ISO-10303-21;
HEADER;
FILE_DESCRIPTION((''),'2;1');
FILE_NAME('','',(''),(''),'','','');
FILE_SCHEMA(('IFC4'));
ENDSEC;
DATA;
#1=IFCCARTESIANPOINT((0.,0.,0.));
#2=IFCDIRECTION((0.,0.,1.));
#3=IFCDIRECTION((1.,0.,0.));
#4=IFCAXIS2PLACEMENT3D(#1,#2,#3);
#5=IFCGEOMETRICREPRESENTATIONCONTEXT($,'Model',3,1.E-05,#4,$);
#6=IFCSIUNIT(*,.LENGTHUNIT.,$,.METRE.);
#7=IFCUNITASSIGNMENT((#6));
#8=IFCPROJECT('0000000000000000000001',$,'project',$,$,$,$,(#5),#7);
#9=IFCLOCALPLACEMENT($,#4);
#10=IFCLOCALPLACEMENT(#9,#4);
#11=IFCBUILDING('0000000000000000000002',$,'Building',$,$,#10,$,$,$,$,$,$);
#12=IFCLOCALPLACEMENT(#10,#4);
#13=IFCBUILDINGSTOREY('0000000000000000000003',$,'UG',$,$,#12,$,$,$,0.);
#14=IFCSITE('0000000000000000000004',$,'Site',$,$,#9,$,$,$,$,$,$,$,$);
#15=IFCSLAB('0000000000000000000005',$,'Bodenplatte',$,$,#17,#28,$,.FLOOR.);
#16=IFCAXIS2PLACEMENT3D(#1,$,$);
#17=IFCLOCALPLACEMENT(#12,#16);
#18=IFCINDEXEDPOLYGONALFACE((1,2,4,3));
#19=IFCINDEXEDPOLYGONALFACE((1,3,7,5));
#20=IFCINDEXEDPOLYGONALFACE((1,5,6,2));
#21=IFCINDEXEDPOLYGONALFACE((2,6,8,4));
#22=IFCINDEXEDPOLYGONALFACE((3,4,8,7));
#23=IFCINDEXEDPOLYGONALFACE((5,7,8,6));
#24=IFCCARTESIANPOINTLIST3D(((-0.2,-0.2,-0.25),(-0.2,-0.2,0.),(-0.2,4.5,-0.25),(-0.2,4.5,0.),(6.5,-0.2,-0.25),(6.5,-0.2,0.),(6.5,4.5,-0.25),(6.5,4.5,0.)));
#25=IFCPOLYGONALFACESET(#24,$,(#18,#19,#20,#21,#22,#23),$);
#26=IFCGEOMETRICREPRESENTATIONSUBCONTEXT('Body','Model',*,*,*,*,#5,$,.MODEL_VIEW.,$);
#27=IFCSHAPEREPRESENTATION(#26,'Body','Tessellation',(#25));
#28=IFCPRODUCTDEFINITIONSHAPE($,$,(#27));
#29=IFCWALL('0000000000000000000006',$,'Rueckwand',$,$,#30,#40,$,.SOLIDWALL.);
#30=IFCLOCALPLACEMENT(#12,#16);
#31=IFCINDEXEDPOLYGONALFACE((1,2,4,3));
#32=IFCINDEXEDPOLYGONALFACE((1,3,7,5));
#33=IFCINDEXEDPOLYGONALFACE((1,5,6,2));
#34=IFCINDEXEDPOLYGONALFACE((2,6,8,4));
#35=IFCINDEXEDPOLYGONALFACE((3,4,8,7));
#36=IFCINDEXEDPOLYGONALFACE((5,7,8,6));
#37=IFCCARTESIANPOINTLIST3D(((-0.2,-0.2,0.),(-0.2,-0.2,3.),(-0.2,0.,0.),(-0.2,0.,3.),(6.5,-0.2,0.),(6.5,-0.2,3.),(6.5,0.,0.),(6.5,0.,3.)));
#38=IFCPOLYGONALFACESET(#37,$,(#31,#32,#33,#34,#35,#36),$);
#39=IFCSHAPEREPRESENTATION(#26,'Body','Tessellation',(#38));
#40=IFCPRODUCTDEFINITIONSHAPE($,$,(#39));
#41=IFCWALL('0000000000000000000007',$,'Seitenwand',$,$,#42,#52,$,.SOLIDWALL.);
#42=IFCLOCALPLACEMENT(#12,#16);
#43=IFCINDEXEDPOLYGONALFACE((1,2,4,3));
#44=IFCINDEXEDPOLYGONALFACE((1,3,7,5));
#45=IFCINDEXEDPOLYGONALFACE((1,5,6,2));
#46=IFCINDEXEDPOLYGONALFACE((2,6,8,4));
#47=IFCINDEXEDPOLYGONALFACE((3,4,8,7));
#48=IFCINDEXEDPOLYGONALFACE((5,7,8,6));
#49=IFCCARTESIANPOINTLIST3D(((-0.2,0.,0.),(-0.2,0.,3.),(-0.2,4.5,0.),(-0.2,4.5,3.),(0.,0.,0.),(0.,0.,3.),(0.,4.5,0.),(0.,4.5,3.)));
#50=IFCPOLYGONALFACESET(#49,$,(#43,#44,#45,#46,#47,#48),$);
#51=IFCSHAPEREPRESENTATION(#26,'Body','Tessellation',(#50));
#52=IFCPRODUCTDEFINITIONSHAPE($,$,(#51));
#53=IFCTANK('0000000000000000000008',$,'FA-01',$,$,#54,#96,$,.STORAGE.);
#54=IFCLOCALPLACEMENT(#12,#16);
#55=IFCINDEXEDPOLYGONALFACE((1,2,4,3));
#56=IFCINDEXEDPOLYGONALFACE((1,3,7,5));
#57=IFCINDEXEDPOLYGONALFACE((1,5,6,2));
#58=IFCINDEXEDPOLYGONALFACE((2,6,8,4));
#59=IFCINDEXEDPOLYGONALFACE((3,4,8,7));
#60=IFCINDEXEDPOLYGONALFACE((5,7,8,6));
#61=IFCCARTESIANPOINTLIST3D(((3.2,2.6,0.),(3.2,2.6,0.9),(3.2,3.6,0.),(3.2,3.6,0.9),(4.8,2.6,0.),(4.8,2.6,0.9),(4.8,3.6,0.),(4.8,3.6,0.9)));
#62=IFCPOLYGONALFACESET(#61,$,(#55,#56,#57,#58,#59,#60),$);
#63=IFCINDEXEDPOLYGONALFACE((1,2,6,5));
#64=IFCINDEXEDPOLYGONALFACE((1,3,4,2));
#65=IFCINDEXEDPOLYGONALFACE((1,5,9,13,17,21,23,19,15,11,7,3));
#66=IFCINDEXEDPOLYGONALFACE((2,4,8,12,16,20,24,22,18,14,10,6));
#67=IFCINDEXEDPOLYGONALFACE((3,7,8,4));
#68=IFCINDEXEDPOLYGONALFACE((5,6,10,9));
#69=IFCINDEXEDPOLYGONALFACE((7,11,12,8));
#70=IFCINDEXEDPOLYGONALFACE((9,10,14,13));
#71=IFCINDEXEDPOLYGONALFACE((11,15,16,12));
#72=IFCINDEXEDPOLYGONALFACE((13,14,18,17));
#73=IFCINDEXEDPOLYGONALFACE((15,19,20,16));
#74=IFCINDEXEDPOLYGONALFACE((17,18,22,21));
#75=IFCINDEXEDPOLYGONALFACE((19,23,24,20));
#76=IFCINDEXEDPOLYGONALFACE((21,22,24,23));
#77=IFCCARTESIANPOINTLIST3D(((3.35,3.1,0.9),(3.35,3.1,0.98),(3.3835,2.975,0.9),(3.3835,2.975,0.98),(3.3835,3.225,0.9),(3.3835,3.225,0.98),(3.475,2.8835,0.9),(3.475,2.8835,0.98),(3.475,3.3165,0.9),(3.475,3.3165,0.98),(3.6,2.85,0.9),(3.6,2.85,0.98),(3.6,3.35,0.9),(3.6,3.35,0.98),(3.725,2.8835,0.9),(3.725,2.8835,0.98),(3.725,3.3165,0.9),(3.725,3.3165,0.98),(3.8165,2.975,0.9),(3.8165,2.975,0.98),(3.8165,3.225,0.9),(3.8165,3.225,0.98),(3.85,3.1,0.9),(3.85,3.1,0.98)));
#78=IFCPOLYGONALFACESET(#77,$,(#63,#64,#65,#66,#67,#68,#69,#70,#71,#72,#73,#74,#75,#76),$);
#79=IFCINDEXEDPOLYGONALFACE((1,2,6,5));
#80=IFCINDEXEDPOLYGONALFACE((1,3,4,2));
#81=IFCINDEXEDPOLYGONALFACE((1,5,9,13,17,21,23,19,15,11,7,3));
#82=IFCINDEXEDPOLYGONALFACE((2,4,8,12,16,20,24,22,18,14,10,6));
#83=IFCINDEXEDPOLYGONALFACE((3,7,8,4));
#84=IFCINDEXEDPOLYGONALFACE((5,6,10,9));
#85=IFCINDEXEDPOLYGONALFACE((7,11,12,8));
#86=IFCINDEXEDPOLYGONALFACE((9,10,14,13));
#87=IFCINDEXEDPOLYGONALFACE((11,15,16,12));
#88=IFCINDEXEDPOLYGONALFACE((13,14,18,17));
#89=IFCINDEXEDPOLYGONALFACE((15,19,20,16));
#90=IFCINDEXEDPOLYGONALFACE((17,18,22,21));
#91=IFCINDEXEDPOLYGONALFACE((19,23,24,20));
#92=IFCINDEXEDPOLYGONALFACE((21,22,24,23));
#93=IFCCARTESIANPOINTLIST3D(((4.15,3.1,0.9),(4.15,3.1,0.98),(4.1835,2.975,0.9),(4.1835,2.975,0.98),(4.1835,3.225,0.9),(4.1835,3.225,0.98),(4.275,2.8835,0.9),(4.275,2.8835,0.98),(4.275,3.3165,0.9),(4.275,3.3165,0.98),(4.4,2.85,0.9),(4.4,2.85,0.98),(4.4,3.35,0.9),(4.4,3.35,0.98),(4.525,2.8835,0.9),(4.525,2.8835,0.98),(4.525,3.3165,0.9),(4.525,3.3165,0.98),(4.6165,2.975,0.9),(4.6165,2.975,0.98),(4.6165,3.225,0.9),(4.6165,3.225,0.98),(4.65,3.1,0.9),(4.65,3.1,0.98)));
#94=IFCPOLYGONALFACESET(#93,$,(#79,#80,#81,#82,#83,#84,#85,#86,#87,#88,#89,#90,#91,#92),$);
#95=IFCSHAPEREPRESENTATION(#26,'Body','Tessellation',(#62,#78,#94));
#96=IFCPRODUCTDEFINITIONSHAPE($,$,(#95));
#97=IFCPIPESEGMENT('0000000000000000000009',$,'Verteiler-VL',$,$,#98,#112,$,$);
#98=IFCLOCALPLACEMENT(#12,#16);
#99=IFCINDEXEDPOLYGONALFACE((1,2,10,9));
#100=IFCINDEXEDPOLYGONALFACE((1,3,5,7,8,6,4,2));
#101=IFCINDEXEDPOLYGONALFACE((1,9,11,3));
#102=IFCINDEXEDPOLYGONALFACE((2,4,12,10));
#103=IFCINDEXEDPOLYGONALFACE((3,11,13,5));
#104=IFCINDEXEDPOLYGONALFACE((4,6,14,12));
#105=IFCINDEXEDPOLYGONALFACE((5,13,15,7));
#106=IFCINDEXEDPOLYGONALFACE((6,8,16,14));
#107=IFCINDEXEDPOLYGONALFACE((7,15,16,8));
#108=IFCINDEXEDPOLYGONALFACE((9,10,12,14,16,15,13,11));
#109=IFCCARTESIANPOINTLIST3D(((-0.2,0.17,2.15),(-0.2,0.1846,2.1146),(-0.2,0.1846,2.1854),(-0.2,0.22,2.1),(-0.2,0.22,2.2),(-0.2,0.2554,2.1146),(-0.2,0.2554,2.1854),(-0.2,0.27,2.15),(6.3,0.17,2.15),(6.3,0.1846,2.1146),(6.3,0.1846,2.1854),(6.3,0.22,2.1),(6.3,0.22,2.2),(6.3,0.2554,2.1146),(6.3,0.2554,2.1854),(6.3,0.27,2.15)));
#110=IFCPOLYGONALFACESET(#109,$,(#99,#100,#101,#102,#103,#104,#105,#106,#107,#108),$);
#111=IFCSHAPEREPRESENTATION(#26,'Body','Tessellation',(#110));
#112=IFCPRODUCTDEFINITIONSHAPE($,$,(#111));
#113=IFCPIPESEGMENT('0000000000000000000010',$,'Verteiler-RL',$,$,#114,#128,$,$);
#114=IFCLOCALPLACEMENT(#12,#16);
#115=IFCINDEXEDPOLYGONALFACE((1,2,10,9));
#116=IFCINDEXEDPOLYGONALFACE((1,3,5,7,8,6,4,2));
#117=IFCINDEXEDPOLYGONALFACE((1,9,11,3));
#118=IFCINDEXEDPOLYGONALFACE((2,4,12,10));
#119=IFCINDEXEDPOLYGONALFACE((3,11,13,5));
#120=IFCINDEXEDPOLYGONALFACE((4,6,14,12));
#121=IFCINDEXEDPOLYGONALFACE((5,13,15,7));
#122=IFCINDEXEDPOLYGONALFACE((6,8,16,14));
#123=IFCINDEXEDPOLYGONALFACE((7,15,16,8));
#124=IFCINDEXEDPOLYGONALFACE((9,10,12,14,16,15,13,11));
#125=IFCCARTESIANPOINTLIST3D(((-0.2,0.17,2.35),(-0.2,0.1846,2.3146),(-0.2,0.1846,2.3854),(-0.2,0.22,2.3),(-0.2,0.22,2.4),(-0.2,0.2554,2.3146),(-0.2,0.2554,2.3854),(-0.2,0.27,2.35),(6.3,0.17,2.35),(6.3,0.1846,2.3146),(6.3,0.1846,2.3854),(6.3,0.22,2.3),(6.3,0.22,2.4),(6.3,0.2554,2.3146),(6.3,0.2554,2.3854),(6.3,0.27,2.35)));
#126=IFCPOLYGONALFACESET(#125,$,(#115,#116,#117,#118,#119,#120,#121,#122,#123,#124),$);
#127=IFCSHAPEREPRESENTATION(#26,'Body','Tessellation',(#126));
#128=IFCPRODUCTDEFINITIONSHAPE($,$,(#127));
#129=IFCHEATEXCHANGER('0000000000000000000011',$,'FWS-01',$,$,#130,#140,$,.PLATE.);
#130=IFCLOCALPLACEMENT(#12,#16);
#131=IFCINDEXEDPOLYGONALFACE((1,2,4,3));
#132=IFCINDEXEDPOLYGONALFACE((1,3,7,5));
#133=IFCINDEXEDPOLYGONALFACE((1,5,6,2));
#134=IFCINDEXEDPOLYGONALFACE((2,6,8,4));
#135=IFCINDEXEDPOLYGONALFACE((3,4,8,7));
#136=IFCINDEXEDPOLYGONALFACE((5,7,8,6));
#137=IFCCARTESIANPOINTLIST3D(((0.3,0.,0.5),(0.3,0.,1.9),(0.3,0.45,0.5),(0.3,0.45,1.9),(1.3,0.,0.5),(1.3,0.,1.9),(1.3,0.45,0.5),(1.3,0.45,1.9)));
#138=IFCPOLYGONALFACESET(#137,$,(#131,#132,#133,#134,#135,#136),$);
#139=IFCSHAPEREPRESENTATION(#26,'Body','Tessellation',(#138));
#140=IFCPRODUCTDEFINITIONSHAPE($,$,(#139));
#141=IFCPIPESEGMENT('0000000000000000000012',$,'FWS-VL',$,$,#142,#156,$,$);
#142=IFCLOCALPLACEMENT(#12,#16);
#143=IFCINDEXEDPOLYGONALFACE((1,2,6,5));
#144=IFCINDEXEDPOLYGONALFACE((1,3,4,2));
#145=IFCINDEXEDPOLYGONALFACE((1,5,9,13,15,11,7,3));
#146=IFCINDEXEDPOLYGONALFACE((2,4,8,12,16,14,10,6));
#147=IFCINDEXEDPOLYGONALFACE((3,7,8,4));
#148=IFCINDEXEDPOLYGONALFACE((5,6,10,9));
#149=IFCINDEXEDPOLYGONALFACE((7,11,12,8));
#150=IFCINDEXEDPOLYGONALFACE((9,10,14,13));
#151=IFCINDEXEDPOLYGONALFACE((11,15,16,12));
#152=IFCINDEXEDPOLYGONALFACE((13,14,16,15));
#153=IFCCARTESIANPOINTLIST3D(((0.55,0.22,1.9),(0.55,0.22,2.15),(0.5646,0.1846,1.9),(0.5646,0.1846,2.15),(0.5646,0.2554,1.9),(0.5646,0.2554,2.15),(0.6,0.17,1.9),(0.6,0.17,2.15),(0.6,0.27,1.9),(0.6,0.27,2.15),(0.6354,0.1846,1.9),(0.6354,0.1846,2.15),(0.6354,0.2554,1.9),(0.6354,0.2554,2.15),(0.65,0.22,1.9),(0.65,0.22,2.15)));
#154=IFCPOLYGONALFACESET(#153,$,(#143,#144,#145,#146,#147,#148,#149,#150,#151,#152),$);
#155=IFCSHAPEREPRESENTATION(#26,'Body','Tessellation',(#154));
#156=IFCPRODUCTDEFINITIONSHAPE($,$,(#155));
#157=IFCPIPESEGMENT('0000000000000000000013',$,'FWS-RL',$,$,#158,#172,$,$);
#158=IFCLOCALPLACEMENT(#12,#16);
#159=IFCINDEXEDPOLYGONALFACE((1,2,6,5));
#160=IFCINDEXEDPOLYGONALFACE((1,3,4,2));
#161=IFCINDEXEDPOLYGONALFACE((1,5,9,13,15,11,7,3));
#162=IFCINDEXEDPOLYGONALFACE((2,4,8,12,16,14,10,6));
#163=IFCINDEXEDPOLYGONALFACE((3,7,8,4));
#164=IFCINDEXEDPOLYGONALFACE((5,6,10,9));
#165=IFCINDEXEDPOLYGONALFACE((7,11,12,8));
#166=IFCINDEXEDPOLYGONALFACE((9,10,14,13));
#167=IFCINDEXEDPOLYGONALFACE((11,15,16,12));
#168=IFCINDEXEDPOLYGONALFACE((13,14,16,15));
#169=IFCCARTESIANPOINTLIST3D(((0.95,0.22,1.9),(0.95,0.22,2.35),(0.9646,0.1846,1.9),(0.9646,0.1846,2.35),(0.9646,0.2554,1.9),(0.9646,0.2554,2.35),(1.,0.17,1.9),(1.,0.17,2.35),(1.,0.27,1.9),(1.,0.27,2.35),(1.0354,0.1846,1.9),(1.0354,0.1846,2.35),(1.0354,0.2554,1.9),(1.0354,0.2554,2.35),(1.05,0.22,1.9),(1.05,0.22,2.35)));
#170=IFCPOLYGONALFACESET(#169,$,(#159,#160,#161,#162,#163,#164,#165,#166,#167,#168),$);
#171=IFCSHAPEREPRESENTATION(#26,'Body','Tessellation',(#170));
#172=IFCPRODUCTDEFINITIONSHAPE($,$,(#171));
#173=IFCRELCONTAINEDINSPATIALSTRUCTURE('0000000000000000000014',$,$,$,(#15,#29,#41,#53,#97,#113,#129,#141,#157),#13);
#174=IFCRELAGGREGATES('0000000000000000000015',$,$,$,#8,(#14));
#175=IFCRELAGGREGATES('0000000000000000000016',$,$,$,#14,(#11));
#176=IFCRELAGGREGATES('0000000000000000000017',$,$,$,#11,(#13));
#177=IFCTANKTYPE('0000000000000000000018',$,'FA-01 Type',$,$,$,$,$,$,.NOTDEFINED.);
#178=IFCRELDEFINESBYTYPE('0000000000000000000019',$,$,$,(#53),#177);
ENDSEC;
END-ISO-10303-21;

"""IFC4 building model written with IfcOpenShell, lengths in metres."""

from ifc_helpers import new_model, si_unit, frame, origin_with_axes, place, context, subcontext, project, spatial, polyline, outline, extrude, type_object, element, save


model = new_model("IFC4")

# Units and contexts
model_context = context("Model", 3, precision=1e-05, world=origin_with_axes())
body_context = subcontext(model_context, "Body", "Model", "MODEL_VIEW")
ifc_project = project(units=[si_unit("LENGTHUNIT", "METRE")], contexts=[model_context])

# Site, building, storey
site_placement = place(None, origin_with_axes())
site = spatial("IfcSite", under=ifc_project, at=site_placement, Name="Site")
building_placement = place(site_placement, origin_with_axes())
building = spatial("IfcBuilding", under=site, at=building_placement, Name="Building")
storey_placement = place(building_placement, origin_with_axes())
storey = spatial("IfcBuildingStorey", under=building, at=storey_placement, Name="UG", Elevation=0.0)

# Slab
slab_placement = place(storey_placement, frame((0.0, 0.0, -0.25), z_axis=(0.0, 0.0, 1.0), x_axis=(1.0, 0.0, 0.0)))
element("IfcSlab", 1, at=slab_placement, inside=storey, Name="Bodenplatte", PredefinedType="FLOOR", context=body_context, shape_type="SweptSolid", body=[
    extrude(outline(polyline([(-0.2, -0.2, 0.0), (6.5, -0.2, 0.0), (6.5, 4.5, 0.0), (-0.2, 4.5, 0.0), (-0.2, -0.2, 0.0)])), origin_with_axes(), (0.0, 0.0, 1.0), 0.25),
])

# Walls
wall_1_placement = place(storey_placement, frame((-0.2, -0.2, 0.0), z_axis=(0.0, 0.0, 1.0), x_axis=(1.0, 0.0, 0.0)))
element("IfcWall", 2, at=wall_1_placement, inside=storey, Name="Rueckwand", PredefinedType="SOLIDWALL", context=body_context, shape_type="SweptSolid", body=[
    extrude(outline(polyline([(0.0, 0.0, 0.0), (6.7, 0.0, 0.0), (6.7, 0.2, 0.0), (0.0, 0.2, 0.0), (0.0, 0.0, 0.0)])), origin_with_axes(), (0.0, 0.0, 1.0), 3.0),
])
wall_2_placement = place(storey_placement, frame((0.0, 0.0, 0.0), z_axis=(0.0, 0.0, 1.0), x_axis=(0.0, 1.0, 0.0)))
element("IfcWall", 3, at=wall_2_placement, inside=storey, Name="Seitenwand", PredefinedType="SOLIDWALL", context=body_context, shape_type="SweptSolid", body=[
    extrude(outline(polyline([(0.0, 0.0, 0.0), (4.5, 0.0, 0.0), (4.5, 0.2, 0.0), (0.0, 0.2, 0.0), (0.0, 0.0, 0.0)])), origin_with_axes(), (0.0, 0.0, 1.0), 3.0),
])

# Tank
tank_type = type_object("IfcTankType", Name="FA-01 Type", PredefinedType="NOTDEFINED")
tank_1_placement = place(storey_placement, origin_with_axes())
element("IfcTank", 4, at=tank_1_placement, inside=storey, type_object=tank_type, Name="FA-01", PredefinedType="STORAGE", context=body_context, shape_type="SweptSolid", body=[
    extrude(outline(polyline([(3.2, 2.6, 0.0), (4.8, 2.6, 0.0), (4.8, 3.6, 0.0), (3.2, 3.6, 0.0), (3.2, 2.6, 0.0)])), origin_with_axes(), (0.0, 0.0, 1.0), 0.9),
    extrude(outline(polyline([(0.25, 0.0, 0.0), (0.2165, 0.125, 0.0), (0.125, 0.2165, 0.0), (0.0, 0.25, 0.0), (-0.125, 0.2165, 0.0), (-0.2165, 0.125, 0.0), (-0.25, 0.0, 0.0), (-0.2165, -0.125, 0.0), (-0.125, -0.2165, 0.0), (0.0, -0.25, 0.0), (0.125, -0.2165, 0.0), (0.2165, -0.125, 0.0), (0.25, 0.0, 0.0)])), frame((3.6, 3.1, 0.9), z_axis=(0.0, 0.0, 1.0), x_axis=(1.0, 0.0, 0.0)), (0.0, 0.0, 1.0), 0.08),
    extrude(outline(polyline([(0.25, 0.0, 0.0), (0.2165, 0.125, 0.0), (0.125, 0.2165, 0.0), (0.0, 0.25, 0.0), (-0.125, 0.2165, 0.0), (-0.2165, 0.125, 0.0), (-0.25, 0.0, 0.0), (-0.2165, -0.125, 0.0), (-0.125, -0.2165, 0.0), (0.0, -0.25, 0.0), (0.125, -0.2165, 0.0), (0.2165, -0.125, 0.0), (0.25, 0.0, 0.0)])), frame((4.4, 3.1, 0.9), z_axis=(0.0, 0.0, 1.0), x_axis=(1.0, 0.0, 0.0)), (0.0, 0.0, 1.0), 0.08),
])

# Pipe segments
pipe_segment_1_placement = place(storey_placement, origin_with_axes())
element("IfcPipeSegment", 5, at=pipe_segment_1_placement, inside=storey, Name="Verteiler-VL", context=body_context, shape_type="SweptSolid", body=[
    extrude(outline(polyline([(0.05, 0.0, 0.0), (0.0354, 0.0354, 0.0), (0.0, 0.05, 0.0), (-0.0354, 0.0354, 0.0), (-0.05, 0.0, 0.0), (-0.0354, -0.0354, 0.0), (0.0, -0.05, 0.0), (0.0354, -0.0354, 0.0), (0.05, 0.0, 0.0)])), frame((-0.2, 0.22, 2.15), z_axis=(1.0, 0.0, 0.0), x_axis=(0.0, 1.0, 0.0)), (0.0, 0.0, 1.0), 6.5),
])
pipe_segment_2_placement = place(storey_placement, origin_with_axes())
element("IfcPipeSegment", 6, at=pipe_segment_2_placement, inside=storey, Name="Verteiler-RL", context=body_context, shape_type="SweptSolid", body=[
    extrude(outline(polyline([(0.05, 0.0, 0.0), (0.0354, 0.0354, 0.0), (0.0, 0.05, 0.0), (-0.0354, 0.0354, 0.0), (-0.05, 0.0, 0.0), (-0.0354, -0.0354, 0.0), (0.0, -0.05, 0.0), (0.0354, -0.0354, 0.0), (0.05, 0.0, 0.0)])), frame((-0.2, 0.22, 2.35), z_axis=(1.0, 0.0, 0.0), x_axis=(0.0, 1.0, 0.0)), (0.0, 0.0, 1.0), 6.5),
])

# Heat exchanger
heat_exchanger_placement = place(storey_placement, origin_with_axes())
element("IfcHeatExchanger", 7, at=heat_exchanger_placement, inside=storey, Name="FWS-01", PredefinedType="PLATE", context=body_context, shape_type="SweptSolid", body=[
    extrude(outline(polyline([(0.3, 0.0, 0.0), (1.3, 0.0, 0.0), (1.3, 0.45, 0.0), (0.3, 0.45, 0.0), (0.3, 0.0, 0.0)])), frame((0.0, 0.0, 0.5), z_axis=(0.0, 0.0, 1.0), x_axis=(1.0, 0.0, 0.0)), (0.0, 0.0, 1.0), 1.4),
])

# Pipe segments
pipe_segment_3_placement = place(storey_placement, origin_with_axes())
element("IfcPipeSegment", 8, at=pipe_segment_3_placement, inside=storey, Name="FWS-VL", context=body_context, shape_type="SweptSolid", body=[
    extrude(outline(polyline([(0.05, 0.0, 0.0), (0.0354, 0.0354, 0.0), (0.0, 0.05, 0.0), (-0.0354, 0.0354, 0.0), (-0.05, 0.0, 0.0), (-0.0354, -0.0354, 0.0), (0.0, -0.05, 0.0), (0.0354, -0.0354, 0.0), (0.05, 0.0, 0.0)])), frame((0.6, 0.22, 1.9), z_axis=(0.0, 0.0, 1.0), x_axis=(1.0, 0.0, 0.0)), (0.0, 0.0, 1.0), 0.25),
])
pipe_segment_4_placement = place(storey_placement, origin_with_axes())
element("IfcPipeSegment", 9, at=pipe_segment_4_placement, inside=storey, Name="FWS-RL", context=body_context, shape_type="SweptSolid", body=[
    extrude(outline(polyline([(0.05, 0.0, 0.0), (0.0354, 0.0354, 0.0), (0.0, 0.05, 0.0), (-0.0354, 0.0354, 0.0), (-0.05, 0.0, 0.0), (-0.0354, -0.0354, 0.0), (0.0, -0.05, 0.0), (0.0354, -0.0354, 0.0), (0.05, 0.0, 0.0)])), frame((1.0, 0.22, 1.9), z_axis=(0.0, 0.0, 1.0), x_axis=(1.0, 0.0, 0.0)), (0.0, 0.0, 1.0), 0.45),
])

save(model, "model.ifc")
